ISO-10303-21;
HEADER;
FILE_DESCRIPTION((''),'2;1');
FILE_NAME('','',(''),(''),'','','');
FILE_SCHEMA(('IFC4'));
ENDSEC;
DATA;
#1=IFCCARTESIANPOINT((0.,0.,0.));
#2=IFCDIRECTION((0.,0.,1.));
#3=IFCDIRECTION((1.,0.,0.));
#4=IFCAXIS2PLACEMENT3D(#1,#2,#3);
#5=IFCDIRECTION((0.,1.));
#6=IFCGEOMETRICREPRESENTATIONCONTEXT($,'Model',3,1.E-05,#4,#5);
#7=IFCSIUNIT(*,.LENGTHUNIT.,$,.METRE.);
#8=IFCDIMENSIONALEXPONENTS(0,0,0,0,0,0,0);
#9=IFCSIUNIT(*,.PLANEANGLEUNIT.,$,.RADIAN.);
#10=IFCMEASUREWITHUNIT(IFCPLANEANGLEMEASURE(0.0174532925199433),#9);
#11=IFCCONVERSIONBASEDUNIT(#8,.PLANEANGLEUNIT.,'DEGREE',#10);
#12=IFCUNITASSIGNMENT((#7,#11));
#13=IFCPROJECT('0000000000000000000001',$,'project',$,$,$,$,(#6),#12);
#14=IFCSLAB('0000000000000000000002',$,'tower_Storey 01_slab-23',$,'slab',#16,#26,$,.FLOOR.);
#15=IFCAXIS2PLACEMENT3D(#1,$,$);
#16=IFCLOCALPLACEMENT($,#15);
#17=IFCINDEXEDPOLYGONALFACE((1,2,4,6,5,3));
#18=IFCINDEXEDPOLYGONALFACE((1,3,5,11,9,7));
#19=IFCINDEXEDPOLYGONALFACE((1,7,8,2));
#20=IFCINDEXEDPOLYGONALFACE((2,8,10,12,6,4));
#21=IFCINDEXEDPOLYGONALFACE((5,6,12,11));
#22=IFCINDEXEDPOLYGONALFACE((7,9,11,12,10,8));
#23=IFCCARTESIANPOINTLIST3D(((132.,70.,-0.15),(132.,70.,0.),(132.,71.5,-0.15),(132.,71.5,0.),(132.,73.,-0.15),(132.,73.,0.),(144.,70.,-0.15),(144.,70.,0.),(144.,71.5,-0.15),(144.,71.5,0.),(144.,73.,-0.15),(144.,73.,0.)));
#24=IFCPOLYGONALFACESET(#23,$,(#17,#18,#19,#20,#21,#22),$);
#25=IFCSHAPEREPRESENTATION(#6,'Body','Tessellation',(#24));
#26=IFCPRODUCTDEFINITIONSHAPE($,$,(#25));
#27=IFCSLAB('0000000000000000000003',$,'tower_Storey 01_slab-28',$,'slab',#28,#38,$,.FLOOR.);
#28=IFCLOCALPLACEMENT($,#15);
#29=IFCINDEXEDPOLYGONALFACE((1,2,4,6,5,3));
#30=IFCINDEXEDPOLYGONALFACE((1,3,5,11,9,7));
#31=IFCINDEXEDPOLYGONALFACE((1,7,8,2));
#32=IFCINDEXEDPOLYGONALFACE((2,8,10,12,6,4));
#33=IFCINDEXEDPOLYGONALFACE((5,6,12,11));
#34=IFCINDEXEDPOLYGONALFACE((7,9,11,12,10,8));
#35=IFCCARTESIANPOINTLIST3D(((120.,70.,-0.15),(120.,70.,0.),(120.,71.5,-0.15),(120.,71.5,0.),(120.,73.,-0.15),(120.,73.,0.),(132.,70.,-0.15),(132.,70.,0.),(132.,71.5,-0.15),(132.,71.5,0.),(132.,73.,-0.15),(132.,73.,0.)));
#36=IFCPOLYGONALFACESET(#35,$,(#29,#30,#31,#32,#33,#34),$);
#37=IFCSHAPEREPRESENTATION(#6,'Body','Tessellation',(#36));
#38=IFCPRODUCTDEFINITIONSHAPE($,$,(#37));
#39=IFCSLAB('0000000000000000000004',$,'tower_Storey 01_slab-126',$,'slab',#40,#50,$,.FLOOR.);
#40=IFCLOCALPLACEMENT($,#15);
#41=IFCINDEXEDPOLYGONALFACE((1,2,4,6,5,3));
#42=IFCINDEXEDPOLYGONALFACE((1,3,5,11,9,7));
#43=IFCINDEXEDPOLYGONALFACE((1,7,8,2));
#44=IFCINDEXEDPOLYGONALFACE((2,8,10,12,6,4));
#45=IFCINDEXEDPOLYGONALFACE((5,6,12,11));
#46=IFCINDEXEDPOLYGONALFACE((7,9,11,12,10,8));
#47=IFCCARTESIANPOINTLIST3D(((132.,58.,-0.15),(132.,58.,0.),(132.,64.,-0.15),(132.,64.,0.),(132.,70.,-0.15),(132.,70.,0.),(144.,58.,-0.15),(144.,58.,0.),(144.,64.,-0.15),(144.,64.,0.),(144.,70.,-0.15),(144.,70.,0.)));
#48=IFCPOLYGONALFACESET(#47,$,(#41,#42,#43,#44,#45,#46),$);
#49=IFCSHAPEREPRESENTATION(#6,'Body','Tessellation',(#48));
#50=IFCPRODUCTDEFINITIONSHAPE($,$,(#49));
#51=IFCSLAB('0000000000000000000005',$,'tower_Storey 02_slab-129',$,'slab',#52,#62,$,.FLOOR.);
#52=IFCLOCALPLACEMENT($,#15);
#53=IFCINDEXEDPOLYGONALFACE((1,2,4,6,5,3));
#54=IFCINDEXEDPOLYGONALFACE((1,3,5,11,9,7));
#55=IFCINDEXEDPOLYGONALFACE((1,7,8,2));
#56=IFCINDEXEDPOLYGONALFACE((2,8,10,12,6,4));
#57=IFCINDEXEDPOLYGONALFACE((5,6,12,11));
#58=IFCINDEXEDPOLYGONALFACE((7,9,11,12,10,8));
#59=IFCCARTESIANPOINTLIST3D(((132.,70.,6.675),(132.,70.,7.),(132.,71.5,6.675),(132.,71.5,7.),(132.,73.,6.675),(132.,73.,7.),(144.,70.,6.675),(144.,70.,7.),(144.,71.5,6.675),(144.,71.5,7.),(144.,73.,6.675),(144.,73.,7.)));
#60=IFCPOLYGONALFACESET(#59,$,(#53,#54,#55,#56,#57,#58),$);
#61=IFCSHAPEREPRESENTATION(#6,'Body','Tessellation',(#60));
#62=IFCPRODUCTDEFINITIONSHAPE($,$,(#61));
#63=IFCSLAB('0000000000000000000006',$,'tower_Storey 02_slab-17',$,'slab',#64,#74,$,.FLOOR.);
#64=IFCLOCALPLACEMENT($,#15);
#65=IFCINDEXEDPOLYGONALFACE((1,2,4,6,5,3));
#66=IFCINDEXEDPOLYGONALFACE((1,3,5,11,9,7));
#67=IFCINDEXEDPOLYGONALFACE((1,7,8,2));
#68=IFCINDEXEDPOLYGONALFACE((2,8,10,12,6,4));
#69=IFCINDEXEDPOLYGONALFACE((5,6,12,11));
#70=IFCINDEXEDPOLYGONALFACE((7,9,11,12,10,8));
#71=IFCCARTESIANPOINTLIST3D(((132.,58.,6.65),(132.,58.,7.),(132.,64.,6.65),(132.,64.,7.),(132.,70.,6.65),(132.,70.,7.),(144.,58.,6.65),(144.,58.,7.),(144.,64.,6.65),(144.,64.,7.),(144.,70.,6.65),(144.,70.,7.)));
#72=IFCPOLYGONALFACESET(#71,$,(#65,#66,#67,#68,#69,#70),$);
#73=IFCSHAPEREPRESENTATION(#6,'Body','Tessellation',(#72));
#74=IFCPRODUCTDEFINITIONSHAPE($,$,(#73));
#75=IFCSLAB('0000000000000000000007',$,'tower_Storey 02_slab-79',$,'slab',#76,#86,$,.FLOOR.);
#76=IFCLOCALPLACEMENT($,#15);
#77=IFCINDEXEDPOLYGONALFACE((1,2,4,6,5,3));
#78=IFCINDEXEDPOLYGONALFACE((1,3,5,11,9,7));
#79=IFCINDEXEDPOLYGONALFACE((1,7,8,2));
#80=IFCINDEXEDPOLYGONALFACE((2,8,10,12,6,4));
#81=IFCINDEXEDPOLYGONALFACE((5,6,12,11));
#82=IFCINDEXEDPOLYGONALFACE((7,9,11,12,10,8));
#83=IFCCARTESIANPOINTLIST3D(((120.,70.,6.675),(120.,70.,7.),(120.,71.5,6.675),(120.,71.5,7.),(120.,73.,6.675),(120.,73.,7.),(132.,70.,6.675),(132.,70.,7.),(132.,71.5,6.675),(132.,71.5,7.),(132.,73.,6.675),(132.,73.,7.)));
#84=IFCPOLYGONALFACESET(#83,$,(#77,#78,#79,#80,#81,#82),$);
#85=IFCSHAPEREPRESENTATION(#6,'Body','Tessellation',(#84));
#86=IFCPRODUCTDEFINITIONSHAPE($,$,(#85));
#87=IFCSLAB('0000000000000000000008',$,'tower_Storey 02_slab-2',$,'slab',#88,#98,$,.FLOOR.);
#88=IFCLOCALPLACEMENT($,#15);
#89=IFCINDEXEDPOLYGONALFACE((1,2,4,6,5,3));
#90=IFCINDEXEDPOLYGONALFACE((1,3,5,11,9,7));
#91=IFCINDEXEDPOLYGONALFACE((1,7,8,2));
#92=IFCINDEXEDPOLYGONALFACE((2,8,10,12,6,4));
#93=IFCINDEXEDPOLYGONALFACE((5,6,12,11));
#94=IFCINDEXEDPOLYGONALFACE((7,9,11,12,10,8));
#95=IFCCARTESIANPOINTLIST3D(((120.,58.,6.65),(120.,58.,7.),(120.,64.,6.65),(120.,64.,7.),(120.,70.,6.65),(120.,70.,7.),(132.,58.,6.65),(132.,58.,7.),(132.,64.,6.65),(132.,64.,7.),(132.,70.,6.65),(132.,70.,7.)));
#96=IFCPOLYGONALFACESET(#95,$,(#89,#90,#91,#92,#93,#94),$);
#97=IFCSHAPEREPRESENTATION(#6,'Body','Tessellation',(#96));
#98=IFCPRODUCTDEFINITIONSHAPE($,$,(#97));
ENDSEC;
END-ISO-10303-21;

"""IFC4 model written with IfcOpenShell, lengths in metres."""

from ifc_helpers import new_model, entity, si_unit, converted_unit, direction, frame, origin_with_axes, place, context, project, polyline, outline, extrude, element, save


model = new_model("IFC4")

# Units and contexts
model_context = context("Model", 3, precision=1e-05, world=origin_with_axes(), true_north=direction((0.0, 1.0)))
ifc_project = project(units=[si_unit("LENGTHUNIT", "METRE"), converted_unit("PLANEANGLEUNIT", "DEGREE", entity("IfcPlaneAngleMeasure", 0.0174532925199433), si_unit("PLANEANGLEUNIT", "RADIAN"), dimensions=[0, 0, 0, 0, 0, 0, 0])], contexts=[model_context])

# Shared definitions
placement_1 = place(None, origin_with_axes())
placement_2 = place(placement_1, origin_with_axes())

# Shared definitions
placement_3 = place(placement_1, frame((0.0, 0.0, 7.0), z_axis=(0.0, 0.0, 1.0), x_axis=(1.0, 0.0, 0.0)))

# Slabs
for number, where, z_axis, x_axis, name in (
    (1, (138.0, 71.5, -0.15), (0.0, 0.0, 1.0), (1.0, 0.0, 0.0), "tower_Storey 01_slab-23"),
    (2, (126.0, 71.5, -0.15), (0.0, 0.0, 1.0), (1.0, 0.0, 0.0), "tower_Storey 01_slab-28"),
):
    element("IfcSlab", number, at=place(placement_2, frame(where, z_axis=z_axis, x_axis=x_axis)), Name=name, ObjectType="slab", PredefinedType="FLOOR", context=model_context, body=[
        extrude(outline(polyline([(-6.0, -1.5, 0.0), (6.0, -1.5, 0.0), (6.0, 0.0, 0.0), (6.0, 1.5, 0.0), (-6.0, 1.5, 0.0), (-6.0, 0.0, 0.0), (-6.0, -1.5, 0.0)])), origin_with_axes(), (0.0, 0.0, 1.0), 0.15),
    ])
slab_1_placement = place(placement_2, frame((138.0, 64.0, -0.15), z_axis=(0.0, 0.0, 1.0), x_axis=(1.0, 0.0, 0.0)))
element("IfcSlab", 3, at=slab_1_placement, Name="tower_Storey 01_slab-126", ObjectType="slab", PredefinedType="FLOOR", context=model_context, body=[
    extrude(outline(polyline([(-6.0, -6.0, 0.0), (6.0, -6.0, 0.0), (6.0, 0.0, 0.0), (6.0, 6.0, 0.0), (-6.0, 6.0, 0.0), (-6.0, 0.0, 0.0), (-6.0, -6.0, 0.0)])), origin_with_axes(), (0.0, 0.0, 1.0), 0.15),
])
slab_2_placement = place(placement_3, frame((138.0, 71.5, -0.325), z_axis=(0.0, 0.0, 1.0), x_axis=(1.0, 0.0, 0.0)))
element("IfcSlab", 4, at=slab_2_placement, Name="tower_Storey 02_slab-129", ObjectType="slab", PredefinedType="FLOOR", context=model_context, body=[
    extrude(outline(polyline([(-6.0, -1.5, 0.0), (6.0, -1.5, 0.0), (6.0, 0.0, 0.0), (6.0, 1.5, 0.0), (-6.0, 1.5, 0.0), (-6.0, 0.0, 0.0), (-6.0, -1.5, 0.0)])), origin_with_axes(), (0.0, 0.0, 1.0), 0.325),
])
slab_3_placement = place(placement_3, frame((138.0, 64.0, -0.35), z_axis=(0.0, 0.0, 1.0), x_axis=(1.0, 0.0, 0.0)))
element("IfcSlab", 5, at=slab_3_placement, Name="tower_Storey 02_slab-17", ObjectType="slab", PredefinedType="FLOOR", context=model_context, body=[
    extrude(outline(polyline([(-6.0, -6.0, 0.0), (6.0, -6.0, 0.0), (6.0, 0.0, 0.0), (6.0, 6.0, 0.0), (-6.0, 6.0, 0.0), (-6.0, 0.0, 0.0), (-6.0, -6.0, 0.0)])), origin_with_axes(), (0.0, 0.0, 1.0), 0.35),
])
slab_4_placement = place(placement_3, frame((126.0, 71.5, -0.325), z_axis=(0.0, 0.0, 1.0), x_axis=(1.0, 0.0, 0.0)))
element("IfcSlab", 6, at=slab_4_placement, Name="tower_Storey 02_slab-79", ObjectType="slab", PredefinedType="FLOOR", context=model_context, body=[
    extrude(outline(polyline([(-6.0, -1.5, 0.0), (6.0, -1.5, 0.0), (6.0, 0.0, 0.0), (6.0, 1.5, 0.0), (-6.0, 1.5, 0.0), (-6.0, 0.0, 0.0), (-6.0, -1.5, 0.0)])), origin_with_axes(), (0.0, 0.0, 1.0), 0.325),
])
slab_5_placement = place(placement_3, frame((126.0, 64.0, -0.35), z_axis=(0.0, 0.0, 1.0), x_axis=(1.0, 0.0, 0.0)))
element("IfcSlab", 7, at=slab_5_placement, Name="tower_Storey 02_slab-2", ObjectType="slab", PredefinedType="FLOOR", context=model_context, body=[
    extrude(outline(polyline([(-6.0, -6.0, 0.0), (6.0, -6.0, 0.0), (6.0, 0.0, 0.0), (6.0, 6.0, 0.0), (-6.0, 6.0, 0.0), (-6.0, 0.0, 0.0), (-6.0, -6.0, 0.0)])), origin_with_axes(), (0.0, 0.0, 1.0), 0.35),
])

save(model, "model.ifc")
